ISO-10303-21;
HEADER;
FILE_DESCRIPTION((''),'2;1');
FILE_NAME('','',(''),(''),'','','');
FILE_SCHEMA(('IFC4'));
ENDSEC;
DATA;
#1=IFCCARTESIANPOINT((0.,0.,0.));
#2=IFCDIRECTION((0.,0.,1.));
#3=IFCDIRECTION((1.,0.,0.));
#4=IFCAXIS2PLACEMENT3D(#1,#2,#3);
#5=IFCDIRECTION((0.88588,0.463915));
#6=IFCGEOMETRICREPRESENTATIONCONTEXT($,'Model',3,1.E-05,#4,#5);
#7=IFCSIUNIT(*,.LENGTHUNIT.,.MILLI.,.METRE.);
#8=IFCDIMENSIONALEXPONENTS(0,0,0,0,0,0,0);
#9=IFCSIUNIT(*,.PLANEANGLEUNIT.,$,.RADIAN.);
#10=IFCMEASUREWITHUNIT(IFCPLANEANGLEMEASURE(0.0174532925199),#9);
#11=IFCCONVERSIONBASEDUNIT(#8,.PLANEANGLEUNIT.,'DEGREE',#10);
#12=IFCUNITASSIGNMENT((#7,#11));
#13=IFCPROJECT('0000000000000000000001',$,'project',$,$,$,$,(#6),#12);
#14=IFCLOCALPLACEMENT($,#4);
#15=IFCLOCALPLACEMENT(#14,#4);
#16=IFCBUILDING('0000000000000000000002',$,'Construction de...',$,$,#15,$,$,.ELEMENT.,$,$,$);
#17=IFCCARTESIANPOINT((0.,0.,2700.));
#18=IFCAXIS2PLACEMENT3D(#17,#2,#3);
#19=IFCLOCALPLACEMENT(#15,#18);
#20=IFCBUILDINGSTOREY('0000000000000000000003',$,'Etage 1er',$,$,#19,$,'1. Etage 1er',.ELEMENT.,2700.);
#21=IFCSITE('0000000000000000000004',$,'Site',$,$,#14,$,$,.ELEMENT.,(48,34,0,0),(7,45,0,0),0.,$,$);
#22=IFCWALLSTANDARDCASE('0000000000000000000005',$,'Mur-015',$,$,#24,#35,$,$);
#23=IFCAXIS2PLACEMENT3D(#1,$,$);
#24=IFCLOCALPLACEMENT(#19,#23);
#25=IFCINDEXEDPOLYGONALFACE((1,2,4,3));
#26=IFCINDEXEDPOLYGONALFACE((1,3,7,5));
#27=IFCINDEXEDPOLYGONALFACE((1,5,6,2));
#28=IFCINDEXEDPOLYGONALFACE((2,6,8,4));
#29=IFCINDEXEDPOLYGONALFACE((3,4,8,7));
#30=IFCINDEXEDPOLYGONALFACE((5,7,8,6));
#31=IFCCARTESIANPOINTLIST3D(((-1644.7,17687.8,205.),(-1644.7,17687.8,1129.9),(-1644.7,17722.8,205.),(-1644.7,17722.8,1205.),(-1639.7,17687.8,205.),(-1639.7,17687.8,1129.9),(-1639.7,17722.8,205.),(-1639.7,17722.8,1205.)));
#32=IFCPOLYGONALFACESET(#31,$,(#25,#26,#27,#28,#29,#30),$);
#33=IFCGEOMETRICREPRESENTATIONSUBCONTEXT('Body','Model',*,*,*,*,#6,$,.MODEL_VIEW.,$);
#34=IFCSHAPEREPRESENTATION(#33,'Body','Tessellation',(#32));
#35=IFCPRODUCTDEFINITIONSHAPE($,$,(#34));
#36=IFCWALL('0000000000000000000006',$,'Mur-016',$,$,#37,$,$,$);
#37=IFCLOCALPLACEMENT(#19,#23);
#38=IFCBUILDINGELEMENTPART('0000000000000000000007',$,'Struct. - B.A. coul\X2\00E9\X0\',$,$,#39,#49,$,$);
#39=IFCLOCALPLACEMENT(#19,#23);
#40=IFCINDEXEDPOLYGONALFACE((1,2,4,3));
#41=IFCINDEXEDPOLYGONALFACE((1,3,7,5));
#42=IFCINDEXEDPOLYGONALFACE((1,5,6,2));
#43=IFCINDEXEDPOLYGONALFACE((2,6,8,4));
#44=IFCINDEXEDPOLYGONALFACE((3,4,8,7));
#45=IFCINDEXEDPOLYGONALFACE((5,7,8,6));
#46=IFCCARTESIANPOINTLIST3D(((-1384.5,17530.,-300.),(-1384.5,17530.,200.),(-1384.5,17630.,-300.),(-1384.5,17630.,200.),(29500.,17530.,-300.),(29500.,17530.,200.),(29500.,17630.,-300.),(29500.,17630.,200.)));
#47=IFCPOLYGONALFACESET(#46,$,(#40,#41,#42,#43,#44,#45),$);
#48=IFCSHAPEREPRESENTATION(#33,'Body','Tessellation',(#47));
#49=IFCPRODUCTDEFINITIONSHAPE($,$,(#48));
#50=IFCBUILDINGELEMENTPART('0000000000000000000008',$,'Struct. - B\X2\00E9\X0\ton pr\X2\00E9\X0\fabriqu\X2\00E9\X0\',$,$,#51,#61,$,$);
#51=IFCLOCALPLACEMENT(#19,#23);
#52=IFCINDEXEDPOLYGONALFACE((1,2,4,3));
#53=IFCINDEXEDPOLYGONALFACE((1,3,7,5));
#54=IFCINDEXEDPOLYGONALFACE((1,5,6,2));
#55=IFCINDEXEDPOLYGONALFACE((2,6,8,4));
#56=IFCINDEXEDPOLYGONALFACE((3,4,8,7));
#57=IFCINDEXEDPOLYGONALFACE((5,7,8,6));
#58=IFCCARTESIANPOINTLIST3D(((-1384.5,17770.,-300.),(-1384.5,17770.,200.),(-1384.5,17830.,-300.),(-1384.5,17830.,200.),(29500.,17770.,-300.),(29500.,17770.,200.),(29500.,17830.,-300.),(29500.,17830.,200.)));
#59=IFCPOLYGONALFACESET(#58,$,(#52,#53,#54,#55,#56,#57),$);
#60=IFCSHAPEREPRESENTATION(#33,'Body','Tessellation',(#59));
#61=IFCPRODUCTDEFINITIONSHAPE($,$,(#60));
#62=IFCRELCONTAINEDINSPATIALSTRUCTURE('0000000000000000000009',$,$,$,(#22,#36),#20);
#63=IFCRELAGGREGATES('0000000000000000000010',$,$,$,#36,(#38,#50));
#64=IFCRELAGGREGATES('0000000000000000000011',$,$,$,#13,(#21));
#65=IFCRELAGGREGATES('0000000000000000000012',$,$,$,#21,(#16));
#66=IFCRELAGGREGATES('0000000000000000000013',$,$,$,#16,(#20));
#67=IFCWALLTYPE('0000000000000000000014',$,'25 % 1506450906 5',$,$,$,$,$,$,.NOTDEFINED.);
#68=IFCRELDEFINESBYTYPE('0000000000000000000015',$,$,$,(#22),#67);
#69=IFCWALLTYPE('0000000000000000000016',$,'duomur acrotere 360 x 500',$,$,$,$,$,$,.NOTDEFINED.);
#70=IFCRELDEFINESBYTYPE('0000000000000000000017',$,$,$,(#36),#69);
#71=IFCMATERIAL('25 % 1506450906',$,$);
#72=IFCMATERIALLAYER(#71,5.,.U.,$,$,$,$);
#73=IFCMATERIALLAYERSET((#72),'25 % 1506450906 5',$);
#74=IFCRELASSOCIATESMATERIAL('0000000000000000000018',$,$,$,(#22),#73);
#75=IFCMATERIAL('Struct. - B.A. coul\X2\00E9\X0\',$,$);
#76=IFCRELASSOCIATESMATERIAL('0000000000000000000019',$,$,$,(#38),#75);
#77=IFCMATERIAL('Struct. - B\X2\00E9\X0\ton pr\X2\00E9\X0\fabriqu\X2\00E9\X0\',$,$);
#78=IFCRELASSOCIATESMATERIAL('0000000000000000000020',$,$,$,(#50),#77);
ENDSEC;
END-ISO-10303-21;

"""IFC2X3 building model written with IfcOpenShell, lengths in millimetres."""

from ifc_helpers import new_model, entity, si_unit, converted_unit, direction, frame, origin_with_axes, place, context, subcontext, project, spatial, polyline, outline, extrude, clip, halfspace, material, layer, layer_set, layer_usage, type_object, element, aggregate, save


model = new_model("IFC2X3")

# Units and contexts
model_context = context("Model", 3, precision=1e-05, world=origin_with_axes(), true_north=direction((0.88588, 0.463915)))
body_context = subcontext(model_context, "Body", "Model", "MODEL_VIEW")
ifc_project = project(units=[si_unit("LENGTHUNIT", "METRE", prefix="MILLI"), converted_unit("PLANEANGLEUNIT", "DEGREE", entity("IfcPlaneAngleMeasure", 0.0174532925199), si_unit("PLANEANGLEUNIT", "RADIAN"), dimensions=[0, 0, 0, 0, 0, 0, 0])], contexts=[model_context])

# Site, building, storey
site_placement = place(None, origin_with_axes())
site = spatial("IfcSite", under=ifc_project, at=site_placement, Name="Site", CompositionType="ELEMENT", RefLatitude=(48, 34, 0, 0), RefLongitude=(7, 45, 0, 0), RefElevation=0.0)
building_placement = place(site_placement, origin_with_axes())
building = spatial("IfcBuilding", under=site, at=building_placement, Name="Construction de...", CompositionType="ELEMENT")
storey_placement = place(building_placement, frame((0.0, 0.0, 2700.0), z_axis=(0.0, 0.0, 1.0), x_axis=(1.0, 0.0, 0.0)))
storey = spatial("IfcBuildingStorey", under=building, at=storey_placement, Name="Etage 1er", LongName="1. Etage 1er", CompositionType="ELEMENT", Elevation=2700.0)

# Shared definitions
ifc_material_1 = material(Name="25 % 1506450906")

# Wall
ifc_layer = layer(ifc_material_1, 5.0, ventilated="UNKNOWN")
ifc_layer_set = layer_set([ifc_layer], Name="25 % 1506450906 5")
ifc_layer_usage = layer_usage(ifc_layer_set, "AXIS2", "NEGATIVE", 2.5)
wall_type_1 = type_object("IfcWallType", Name="25 % 1506450906 5", PredefinedType="NOTDEFINED")
wall_1_placement = place(storey_placement, frame((-1642.2, 17722.8, 205.0), z_axis=(0.0, 0.0, 1.0), x_axis=(0.0, -1.0, 0.0)))
element("IfcWallStandardCase", 1, at=wall_1_placement, inside=storey, type_object=wall_type_1, material=ifc_layer_usage, Name="Mur-015", context=body_context, shape_type="Clipping", body=[
    clip(extrude(outline(polyline([(0.0, -2.5), (35.0, -2.5), (35.0, 2.5), (0.0, 2.5), (0.0, -2.5)])), origin_with_axes(), (0.0, 0.0, 1.0), 1000.0), halfspace(frame((383.0, 0.0, 178.6), z_axis=(-0.906308, 0.0, -0.422618), x_axis=(0.0, 1.0, 0.0)), True)),
])

# Wall, building element parts
wall_type_2 = type_object("IfcWallType", Name="duomur acrotere 360 x 500", PredefinedType="NOTDEFINED")
wall_2_placement = place(storey_placement, frame((-1384.5, 17730.0, -300.0), z_axis=(0.0, 0.0, 1.0), x_axis=(1.0, 0.0, 0.0)))
wall_2 = element("IfcWall", 2, at=wall_2_placement, inside=storey, type_object=wall_type_2, Name="Mur-016")
ifc_material_2 = material(Name="Struct. - B.A. coulé")
building_element_part_1_placement = place(wall_2_placement, origin_with_axes())
building_element_part_1 = element("IfcBuildingElementPart", 3, at=building_element_part_1_placement, material=ifc_material_2, Name="Struct. - B.A. coulé", context=body_context, shape_type="SweptSolid", body=[
    extrude(outline(polyline([(-300.0, 0.0), (-200.0, 0.0), (-200.0, 500.0), (-300.0, 500.0), (-300.0, 0.0)])), frame((0.0, 100.0, 0.0), z_axis=(1.0, 0.0, 0.0), x_axis=(0.0, 1.0, 0.0)), (0.0, 0.0, 1.0), 30884.5),
])
ifc_material_3 = material(Name="Struct. - Béton préfabriqué")
building_element_part_2_placement = place(wall_2_placement, origin_with_axes())
building_element_part_2 = element("IfcBuildingElementPart", 4, at=building_element_part_2_placement, material=ifc_material_3, Name="Struct. - Béton préfabriqué", context=body_context, shape_type="SweptSolid", body=[
    extrude(outline(polyline([(-60.0, 0.0), (0.0, 0.0), (0.0, 500.0), (-60.0, 500.0), (-60.0, 0.0)])), frame((0.0, 100.0, 0.0), z_axis=(1.0, 0.0, 0.0), x_axis=(0.0, 1.0, 0.0)), (0.0, 0.0, 1.0), 30884.5),
])
aggregate(wall_2, [building_element_part_1, building_element_part_2])

save(model, "model.ifc")
